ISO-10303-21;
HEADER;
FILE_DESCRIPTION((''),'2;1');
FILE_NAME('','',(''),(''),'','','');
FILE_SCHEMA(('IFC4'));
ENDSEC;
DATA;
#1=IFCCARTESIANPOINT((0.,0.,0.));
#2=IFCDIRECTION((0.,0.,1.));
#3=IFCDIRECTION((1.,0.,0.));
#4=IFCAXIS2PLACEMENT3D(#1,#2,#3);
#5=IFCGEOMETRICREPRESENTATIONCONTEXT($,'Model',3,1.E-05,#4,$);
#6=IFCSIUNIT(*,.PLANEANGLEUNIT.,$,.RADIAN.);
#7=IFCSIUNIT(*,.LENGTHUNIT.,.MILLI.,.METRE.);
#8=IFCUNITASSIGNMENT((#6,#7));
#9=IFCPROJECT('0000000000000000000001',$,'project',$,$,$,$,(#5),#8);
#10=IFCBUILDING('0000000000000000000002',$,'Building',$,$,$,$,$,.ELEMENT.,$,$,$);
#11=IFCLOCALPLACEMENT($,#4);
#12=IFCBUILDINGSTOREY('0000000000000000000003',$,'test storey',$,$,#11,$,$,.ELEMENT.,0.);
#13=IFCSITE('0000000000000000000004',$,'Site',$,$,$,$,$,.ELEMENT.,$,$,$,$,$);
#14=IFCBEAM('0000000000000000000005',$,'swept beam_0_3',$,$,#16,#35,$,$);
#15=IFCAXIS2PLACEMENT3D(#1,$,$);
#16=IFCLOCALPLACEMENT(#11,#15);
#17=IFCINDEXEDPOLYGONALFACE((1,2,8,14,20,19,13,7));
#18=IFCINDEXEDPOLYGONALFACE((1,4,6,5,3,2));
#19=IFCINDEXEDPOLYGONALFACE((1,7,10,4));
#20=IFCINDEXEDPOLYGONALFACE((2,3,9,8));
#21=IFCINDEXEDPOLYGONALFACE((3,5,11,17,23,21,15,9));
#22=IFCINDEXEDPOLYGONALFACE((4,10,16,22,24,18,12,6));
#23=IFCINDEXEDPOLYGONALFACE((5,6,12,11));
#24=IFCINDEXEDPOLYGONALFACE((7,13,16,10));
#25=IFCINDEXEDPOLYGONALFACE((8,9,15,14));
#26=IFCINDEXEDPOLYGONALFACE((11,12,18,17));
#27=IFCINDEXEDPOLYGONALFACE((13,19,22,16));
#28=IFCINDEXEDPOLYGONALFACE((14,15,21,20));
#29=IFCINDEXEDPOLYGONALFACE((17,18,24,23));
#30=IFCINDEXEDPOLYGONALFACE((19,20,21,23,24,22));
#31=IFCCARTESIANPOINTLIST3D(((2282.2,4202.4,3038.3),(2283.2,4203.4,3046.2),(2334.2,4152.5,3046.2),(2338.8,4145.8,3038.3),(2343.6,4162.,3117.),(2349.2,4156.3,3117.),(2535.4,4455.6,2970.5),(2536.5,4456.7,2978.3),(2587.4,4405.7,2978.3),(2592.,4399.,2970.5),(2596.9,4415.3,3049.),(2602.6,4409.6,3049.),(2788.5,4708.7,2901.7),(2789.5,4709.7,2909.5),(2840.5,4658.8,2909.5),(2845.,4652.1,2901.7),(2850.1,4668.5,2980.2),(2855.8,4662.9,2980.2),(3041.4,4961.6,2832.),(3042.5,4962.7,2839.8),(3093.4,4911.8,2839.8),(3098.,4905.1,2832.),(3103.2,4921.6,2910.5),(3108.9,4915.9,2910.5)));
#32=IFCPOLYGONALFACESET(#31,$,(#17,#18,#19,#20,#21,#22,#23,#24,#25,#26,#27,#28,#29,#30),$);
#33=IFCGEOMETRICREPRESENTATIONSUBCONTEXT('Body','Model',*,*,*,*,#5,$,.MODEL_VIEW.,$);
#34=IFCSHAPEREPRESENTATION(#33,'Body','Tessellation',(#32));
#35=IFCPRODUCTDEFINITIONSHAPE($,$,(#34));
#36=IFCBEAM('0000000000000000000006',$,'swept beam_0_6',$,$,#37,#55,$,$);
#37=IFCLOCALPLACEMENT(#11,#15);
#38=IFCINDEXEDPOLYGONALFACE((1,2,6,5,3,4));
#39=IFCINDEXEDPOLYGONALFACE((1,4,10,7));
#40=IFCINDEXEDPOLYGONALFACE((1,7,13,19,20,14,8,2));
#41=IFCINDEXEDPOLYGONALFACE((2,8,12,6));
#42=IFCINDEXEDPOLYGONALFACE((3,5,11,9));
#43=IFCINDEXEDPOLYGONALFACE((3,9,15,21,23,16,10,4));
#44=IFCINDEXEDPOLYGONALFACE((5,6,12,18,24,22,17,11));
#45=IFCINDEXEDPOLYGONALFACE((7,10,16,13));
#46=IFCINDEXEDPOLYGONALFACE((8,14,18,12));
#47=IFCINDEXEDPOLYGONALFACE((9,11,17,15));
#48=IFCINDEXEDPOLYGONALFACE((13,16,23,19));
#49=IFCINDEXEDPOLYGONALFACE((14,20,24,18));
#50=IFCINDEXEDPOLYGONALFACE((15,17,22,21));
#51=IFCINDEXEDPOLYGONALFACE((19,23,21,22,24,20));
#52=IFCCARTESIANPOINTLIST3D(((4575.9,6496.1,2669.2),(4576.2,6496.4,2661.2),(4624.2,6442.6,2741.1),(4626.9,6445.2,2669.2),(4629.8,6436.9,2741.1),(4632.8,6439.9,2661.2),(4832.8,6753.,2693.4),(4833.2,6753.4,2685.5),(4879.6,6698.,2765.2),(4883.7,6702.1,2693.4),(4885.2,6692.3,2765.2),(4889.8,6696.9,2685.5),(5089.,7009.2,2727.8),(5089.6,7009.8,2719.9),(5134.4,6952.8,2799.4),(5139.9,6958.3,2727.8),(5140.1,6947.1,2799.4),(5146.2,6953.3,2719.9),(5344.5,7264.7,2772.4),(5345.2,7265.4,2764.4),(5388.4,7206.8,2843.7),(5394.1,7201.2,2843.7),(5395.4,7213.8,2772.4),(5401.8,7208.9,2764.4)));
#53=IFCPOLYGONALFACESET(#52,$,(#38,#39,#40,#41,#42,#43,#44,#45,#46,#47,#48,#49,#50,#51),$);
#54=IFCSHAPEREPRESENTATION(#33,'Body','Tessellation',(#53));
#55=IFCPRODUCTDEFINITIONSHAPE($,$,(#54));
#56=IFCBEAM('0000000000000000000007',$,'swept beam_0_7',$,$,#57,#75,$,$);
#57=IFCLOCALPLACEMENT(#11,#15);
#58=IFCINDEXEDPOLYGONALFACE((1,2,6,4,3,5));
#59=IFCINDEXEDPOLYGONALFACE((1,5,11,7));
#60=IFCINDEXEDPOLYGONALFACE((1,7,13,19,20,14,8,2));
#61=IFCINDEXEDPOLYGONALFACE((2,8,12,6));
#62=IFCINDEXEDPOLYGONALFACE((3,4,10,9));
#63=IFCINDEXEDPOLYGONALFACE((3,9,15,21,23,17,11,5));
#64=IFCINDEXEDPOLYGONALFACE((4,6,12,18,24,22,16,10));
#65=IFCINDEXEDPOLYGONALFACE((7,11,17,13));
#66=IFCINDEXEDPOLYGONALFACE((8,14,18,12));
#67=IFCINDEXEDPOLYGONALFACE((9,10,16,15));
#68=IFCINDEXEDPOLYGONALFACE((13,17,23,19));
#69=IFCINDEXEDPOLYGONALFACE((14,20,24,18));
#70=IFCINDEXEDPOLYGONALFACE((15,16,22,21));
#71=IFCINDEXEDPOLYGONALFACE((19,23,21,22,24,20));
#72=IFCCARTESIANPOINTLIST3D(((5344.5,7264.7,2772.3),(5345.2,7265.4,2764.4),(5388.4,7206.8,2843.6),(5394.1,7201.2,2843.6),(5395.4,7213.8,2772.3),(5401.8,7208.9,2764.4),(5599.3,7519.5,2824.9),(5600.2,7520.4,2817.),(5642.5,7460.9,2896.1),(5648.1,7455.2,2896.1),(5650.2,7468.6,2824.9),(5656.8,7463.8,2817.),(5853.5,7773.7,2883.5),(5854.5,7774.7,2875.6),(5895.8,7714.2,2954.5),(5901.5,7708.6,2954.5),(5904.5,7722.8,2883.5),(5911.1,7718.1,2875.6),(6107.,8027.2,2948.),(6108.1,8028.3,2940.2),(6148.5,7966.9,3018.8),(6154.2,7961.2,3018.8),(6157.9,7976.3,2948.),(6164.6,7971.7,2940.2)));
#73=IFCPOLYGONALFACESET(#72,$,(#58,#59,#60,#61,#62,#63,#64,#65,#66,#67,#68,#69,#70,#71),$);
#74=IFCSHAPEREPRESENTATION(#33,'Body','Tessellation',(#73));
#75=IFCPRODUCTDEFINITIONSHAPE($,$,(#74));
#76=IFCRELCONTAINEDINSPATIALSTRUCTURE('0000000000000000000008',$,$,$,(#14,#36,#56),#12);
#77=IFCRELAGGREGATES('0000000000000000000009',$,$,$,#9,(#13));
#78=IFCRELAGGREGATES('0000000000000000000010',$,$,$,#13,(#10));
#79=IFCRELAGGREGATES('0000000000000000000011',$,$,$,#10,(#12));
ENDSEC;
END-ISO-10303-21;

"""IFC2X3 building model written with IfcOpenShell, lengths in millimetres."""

from ifc_helpers import new_model, entity, si_unit, origin_with_axes, place, context, subcontext, project, spatial, element, save


model = new_model("IFC2X3")

# Units and contexts
model_context = context("Model", 3, precision=1e-05, world=origin_with_axes())
body_context = subcontext(model_context, "Body", "Model", "MODEL_VIEW")
ifc_project = project(units=[si_unit("PLANEANGLEUNIT", "RADIAN"), si_unit("LENGTHUNIT", "METRE", prefix="MILLI")], contexts=[model_context])

# Site, building, storey
site = spatial("IfcSite", under=ifc_project, Name="Site", CompositionType="ELEMENT")
building = spatial("IfcBuilding", under=site, Name="Building", CompositionType="ELEMENT")
storey_placement = place(None, origin_with_axes())
storey = spatial("IfcBuildingStorey", under=building, at=storey_placement, Name="test storey", CompositionType="ELEMENT", Elevation=0.0)

# Beams
beam_1_placement = place(storey_placement, origin_with_axes())
element("IfcBeam", 1, at=beam_1_placement, inside=storey, Name="swept beam_0_3", context=body_context, shape_type="SweptSolid", body=[
    entity("IfcRevolvedAreaSolid", entity("IfcArbitraryClosedProfileDef", "AREA", None, entity("IfcPolyline", [entity("IfcCartesianPoint", [80.0, -40.0]), entity("IfcCartesianPoint", [80.0, -32.0]), entity("IfcCartesianPoint", [8.0, -32.0]), entity("IfcCartesianPoint", [8.0, 40.0]), entity("IfcCartesianPoint", [0.0, 40.0]), entity("IfcCartesianPoint", [0.0, -40.0]), entity("IfcCartesianPoint", [80.0, -40.0])])), entity("IfcAxis2Placement3D", entity("IfcCartesianPoint", [2310.5, 4174.1, 3038.3]), entity("IfcDirection", [-0.6949, -0.6949, 0.185]), entity("IfcDirection", [0.1308, 0.1308, 0.9827])), entity("IfcAxis1Placement", entity("IfcCartesianPoint", [-143292.6, 0.0, 0.0]), entity("IfcDirection", [0.0, 1.0, 0.0])), 0.00763),
])
beam_2_placement = place(storey_placement, origin_with_axes())
element("IfcBeam", 2, at=beam_2_placement, inside=storey, Name="swept beam_0_6", context=body_context, shape_type="SweptSolid", body=[
    entity("IfcRevolvedAreaSolid", entity("IfcArbitraryClosedProfileDef", "AREA", None, entity("IfcPolyline", [entity("IfcCartesianPoint", [-80.0, 40.0]), entity("IfcCartesianPoint", [-80.0, 32.0]), entity("IfcCartesianPoint", [-8.0, 32.0]), entity("IfcCartesianPoint", [-8.0, -40.0]), entity("IfcCartesianPoint", [0.0, -40.0]), entity("IfcCartesianPoint", [0.0, 40.0]), entity("IfcCartesianPoint", [-80.0, 40.0])])), entity("IfcAxis2Placement3D", entity("IfcCartesianPoint", [4604.5, 6468.2, 2661.2]), entity("IfcDirection", [-0.7061, -0.7061, -0.0526]), entity("IfcDirection", [0.0372, 0.0372, -0.9986])), entity("IfcAxis1Placement", entity("IfcCartesianPoint", [-13006.7, 0.0, 0.0]), entity("IfcDirection", [0.0, 1.0, 0.0])), 0.084013),
])
beam_3_placement = place(storey_placement, origin_with_axes())
element("IfcBeam", 3, at=beam_3_placement, inside=storey, Name="swept beam_0_7", context=body_context, shape_type="SweptSolid", body=[
    entity("IfcRevolvedAreaSolid", entity("IfcArbitraryClosedProfileDef", "AREA", None, entity("IfcPolyline", [entity("IfcCartesianPoint", [-80.0, 40.0]), entity("IfcCartesianPoint", [-80.0, 32.0]), entity("IfcCartesianPoint", [-8.0, 32.0]), entity("IfcCartesianPoint", [-8.0, -40.0]), entity("IfcCartesianPoint", [0.0, -40.0]), entity("IfcCartesianPoint", [0.0, 40.0]), entity("IfcCartesianPoint", [-80.0, 40.0])])), entity("IfcAxis2Placement3D", entity("IfcCartesianPoint", [5373.5, 7237.2, 2764.4]), entity("IfcDirection", [-0.7005, -0.7005, -0.1362]), entity("IfcDirection", [0.0963, 0.0963, -0.9907])), entity("IfcAxis1Placement", entity("IfcCartesianPoint", [-21958.7, 0.0, 0.0]), entity("IfcDirection", [0.0, 1.0, 0.0])), 0.049782),
])

save(model, "model.ifc")
